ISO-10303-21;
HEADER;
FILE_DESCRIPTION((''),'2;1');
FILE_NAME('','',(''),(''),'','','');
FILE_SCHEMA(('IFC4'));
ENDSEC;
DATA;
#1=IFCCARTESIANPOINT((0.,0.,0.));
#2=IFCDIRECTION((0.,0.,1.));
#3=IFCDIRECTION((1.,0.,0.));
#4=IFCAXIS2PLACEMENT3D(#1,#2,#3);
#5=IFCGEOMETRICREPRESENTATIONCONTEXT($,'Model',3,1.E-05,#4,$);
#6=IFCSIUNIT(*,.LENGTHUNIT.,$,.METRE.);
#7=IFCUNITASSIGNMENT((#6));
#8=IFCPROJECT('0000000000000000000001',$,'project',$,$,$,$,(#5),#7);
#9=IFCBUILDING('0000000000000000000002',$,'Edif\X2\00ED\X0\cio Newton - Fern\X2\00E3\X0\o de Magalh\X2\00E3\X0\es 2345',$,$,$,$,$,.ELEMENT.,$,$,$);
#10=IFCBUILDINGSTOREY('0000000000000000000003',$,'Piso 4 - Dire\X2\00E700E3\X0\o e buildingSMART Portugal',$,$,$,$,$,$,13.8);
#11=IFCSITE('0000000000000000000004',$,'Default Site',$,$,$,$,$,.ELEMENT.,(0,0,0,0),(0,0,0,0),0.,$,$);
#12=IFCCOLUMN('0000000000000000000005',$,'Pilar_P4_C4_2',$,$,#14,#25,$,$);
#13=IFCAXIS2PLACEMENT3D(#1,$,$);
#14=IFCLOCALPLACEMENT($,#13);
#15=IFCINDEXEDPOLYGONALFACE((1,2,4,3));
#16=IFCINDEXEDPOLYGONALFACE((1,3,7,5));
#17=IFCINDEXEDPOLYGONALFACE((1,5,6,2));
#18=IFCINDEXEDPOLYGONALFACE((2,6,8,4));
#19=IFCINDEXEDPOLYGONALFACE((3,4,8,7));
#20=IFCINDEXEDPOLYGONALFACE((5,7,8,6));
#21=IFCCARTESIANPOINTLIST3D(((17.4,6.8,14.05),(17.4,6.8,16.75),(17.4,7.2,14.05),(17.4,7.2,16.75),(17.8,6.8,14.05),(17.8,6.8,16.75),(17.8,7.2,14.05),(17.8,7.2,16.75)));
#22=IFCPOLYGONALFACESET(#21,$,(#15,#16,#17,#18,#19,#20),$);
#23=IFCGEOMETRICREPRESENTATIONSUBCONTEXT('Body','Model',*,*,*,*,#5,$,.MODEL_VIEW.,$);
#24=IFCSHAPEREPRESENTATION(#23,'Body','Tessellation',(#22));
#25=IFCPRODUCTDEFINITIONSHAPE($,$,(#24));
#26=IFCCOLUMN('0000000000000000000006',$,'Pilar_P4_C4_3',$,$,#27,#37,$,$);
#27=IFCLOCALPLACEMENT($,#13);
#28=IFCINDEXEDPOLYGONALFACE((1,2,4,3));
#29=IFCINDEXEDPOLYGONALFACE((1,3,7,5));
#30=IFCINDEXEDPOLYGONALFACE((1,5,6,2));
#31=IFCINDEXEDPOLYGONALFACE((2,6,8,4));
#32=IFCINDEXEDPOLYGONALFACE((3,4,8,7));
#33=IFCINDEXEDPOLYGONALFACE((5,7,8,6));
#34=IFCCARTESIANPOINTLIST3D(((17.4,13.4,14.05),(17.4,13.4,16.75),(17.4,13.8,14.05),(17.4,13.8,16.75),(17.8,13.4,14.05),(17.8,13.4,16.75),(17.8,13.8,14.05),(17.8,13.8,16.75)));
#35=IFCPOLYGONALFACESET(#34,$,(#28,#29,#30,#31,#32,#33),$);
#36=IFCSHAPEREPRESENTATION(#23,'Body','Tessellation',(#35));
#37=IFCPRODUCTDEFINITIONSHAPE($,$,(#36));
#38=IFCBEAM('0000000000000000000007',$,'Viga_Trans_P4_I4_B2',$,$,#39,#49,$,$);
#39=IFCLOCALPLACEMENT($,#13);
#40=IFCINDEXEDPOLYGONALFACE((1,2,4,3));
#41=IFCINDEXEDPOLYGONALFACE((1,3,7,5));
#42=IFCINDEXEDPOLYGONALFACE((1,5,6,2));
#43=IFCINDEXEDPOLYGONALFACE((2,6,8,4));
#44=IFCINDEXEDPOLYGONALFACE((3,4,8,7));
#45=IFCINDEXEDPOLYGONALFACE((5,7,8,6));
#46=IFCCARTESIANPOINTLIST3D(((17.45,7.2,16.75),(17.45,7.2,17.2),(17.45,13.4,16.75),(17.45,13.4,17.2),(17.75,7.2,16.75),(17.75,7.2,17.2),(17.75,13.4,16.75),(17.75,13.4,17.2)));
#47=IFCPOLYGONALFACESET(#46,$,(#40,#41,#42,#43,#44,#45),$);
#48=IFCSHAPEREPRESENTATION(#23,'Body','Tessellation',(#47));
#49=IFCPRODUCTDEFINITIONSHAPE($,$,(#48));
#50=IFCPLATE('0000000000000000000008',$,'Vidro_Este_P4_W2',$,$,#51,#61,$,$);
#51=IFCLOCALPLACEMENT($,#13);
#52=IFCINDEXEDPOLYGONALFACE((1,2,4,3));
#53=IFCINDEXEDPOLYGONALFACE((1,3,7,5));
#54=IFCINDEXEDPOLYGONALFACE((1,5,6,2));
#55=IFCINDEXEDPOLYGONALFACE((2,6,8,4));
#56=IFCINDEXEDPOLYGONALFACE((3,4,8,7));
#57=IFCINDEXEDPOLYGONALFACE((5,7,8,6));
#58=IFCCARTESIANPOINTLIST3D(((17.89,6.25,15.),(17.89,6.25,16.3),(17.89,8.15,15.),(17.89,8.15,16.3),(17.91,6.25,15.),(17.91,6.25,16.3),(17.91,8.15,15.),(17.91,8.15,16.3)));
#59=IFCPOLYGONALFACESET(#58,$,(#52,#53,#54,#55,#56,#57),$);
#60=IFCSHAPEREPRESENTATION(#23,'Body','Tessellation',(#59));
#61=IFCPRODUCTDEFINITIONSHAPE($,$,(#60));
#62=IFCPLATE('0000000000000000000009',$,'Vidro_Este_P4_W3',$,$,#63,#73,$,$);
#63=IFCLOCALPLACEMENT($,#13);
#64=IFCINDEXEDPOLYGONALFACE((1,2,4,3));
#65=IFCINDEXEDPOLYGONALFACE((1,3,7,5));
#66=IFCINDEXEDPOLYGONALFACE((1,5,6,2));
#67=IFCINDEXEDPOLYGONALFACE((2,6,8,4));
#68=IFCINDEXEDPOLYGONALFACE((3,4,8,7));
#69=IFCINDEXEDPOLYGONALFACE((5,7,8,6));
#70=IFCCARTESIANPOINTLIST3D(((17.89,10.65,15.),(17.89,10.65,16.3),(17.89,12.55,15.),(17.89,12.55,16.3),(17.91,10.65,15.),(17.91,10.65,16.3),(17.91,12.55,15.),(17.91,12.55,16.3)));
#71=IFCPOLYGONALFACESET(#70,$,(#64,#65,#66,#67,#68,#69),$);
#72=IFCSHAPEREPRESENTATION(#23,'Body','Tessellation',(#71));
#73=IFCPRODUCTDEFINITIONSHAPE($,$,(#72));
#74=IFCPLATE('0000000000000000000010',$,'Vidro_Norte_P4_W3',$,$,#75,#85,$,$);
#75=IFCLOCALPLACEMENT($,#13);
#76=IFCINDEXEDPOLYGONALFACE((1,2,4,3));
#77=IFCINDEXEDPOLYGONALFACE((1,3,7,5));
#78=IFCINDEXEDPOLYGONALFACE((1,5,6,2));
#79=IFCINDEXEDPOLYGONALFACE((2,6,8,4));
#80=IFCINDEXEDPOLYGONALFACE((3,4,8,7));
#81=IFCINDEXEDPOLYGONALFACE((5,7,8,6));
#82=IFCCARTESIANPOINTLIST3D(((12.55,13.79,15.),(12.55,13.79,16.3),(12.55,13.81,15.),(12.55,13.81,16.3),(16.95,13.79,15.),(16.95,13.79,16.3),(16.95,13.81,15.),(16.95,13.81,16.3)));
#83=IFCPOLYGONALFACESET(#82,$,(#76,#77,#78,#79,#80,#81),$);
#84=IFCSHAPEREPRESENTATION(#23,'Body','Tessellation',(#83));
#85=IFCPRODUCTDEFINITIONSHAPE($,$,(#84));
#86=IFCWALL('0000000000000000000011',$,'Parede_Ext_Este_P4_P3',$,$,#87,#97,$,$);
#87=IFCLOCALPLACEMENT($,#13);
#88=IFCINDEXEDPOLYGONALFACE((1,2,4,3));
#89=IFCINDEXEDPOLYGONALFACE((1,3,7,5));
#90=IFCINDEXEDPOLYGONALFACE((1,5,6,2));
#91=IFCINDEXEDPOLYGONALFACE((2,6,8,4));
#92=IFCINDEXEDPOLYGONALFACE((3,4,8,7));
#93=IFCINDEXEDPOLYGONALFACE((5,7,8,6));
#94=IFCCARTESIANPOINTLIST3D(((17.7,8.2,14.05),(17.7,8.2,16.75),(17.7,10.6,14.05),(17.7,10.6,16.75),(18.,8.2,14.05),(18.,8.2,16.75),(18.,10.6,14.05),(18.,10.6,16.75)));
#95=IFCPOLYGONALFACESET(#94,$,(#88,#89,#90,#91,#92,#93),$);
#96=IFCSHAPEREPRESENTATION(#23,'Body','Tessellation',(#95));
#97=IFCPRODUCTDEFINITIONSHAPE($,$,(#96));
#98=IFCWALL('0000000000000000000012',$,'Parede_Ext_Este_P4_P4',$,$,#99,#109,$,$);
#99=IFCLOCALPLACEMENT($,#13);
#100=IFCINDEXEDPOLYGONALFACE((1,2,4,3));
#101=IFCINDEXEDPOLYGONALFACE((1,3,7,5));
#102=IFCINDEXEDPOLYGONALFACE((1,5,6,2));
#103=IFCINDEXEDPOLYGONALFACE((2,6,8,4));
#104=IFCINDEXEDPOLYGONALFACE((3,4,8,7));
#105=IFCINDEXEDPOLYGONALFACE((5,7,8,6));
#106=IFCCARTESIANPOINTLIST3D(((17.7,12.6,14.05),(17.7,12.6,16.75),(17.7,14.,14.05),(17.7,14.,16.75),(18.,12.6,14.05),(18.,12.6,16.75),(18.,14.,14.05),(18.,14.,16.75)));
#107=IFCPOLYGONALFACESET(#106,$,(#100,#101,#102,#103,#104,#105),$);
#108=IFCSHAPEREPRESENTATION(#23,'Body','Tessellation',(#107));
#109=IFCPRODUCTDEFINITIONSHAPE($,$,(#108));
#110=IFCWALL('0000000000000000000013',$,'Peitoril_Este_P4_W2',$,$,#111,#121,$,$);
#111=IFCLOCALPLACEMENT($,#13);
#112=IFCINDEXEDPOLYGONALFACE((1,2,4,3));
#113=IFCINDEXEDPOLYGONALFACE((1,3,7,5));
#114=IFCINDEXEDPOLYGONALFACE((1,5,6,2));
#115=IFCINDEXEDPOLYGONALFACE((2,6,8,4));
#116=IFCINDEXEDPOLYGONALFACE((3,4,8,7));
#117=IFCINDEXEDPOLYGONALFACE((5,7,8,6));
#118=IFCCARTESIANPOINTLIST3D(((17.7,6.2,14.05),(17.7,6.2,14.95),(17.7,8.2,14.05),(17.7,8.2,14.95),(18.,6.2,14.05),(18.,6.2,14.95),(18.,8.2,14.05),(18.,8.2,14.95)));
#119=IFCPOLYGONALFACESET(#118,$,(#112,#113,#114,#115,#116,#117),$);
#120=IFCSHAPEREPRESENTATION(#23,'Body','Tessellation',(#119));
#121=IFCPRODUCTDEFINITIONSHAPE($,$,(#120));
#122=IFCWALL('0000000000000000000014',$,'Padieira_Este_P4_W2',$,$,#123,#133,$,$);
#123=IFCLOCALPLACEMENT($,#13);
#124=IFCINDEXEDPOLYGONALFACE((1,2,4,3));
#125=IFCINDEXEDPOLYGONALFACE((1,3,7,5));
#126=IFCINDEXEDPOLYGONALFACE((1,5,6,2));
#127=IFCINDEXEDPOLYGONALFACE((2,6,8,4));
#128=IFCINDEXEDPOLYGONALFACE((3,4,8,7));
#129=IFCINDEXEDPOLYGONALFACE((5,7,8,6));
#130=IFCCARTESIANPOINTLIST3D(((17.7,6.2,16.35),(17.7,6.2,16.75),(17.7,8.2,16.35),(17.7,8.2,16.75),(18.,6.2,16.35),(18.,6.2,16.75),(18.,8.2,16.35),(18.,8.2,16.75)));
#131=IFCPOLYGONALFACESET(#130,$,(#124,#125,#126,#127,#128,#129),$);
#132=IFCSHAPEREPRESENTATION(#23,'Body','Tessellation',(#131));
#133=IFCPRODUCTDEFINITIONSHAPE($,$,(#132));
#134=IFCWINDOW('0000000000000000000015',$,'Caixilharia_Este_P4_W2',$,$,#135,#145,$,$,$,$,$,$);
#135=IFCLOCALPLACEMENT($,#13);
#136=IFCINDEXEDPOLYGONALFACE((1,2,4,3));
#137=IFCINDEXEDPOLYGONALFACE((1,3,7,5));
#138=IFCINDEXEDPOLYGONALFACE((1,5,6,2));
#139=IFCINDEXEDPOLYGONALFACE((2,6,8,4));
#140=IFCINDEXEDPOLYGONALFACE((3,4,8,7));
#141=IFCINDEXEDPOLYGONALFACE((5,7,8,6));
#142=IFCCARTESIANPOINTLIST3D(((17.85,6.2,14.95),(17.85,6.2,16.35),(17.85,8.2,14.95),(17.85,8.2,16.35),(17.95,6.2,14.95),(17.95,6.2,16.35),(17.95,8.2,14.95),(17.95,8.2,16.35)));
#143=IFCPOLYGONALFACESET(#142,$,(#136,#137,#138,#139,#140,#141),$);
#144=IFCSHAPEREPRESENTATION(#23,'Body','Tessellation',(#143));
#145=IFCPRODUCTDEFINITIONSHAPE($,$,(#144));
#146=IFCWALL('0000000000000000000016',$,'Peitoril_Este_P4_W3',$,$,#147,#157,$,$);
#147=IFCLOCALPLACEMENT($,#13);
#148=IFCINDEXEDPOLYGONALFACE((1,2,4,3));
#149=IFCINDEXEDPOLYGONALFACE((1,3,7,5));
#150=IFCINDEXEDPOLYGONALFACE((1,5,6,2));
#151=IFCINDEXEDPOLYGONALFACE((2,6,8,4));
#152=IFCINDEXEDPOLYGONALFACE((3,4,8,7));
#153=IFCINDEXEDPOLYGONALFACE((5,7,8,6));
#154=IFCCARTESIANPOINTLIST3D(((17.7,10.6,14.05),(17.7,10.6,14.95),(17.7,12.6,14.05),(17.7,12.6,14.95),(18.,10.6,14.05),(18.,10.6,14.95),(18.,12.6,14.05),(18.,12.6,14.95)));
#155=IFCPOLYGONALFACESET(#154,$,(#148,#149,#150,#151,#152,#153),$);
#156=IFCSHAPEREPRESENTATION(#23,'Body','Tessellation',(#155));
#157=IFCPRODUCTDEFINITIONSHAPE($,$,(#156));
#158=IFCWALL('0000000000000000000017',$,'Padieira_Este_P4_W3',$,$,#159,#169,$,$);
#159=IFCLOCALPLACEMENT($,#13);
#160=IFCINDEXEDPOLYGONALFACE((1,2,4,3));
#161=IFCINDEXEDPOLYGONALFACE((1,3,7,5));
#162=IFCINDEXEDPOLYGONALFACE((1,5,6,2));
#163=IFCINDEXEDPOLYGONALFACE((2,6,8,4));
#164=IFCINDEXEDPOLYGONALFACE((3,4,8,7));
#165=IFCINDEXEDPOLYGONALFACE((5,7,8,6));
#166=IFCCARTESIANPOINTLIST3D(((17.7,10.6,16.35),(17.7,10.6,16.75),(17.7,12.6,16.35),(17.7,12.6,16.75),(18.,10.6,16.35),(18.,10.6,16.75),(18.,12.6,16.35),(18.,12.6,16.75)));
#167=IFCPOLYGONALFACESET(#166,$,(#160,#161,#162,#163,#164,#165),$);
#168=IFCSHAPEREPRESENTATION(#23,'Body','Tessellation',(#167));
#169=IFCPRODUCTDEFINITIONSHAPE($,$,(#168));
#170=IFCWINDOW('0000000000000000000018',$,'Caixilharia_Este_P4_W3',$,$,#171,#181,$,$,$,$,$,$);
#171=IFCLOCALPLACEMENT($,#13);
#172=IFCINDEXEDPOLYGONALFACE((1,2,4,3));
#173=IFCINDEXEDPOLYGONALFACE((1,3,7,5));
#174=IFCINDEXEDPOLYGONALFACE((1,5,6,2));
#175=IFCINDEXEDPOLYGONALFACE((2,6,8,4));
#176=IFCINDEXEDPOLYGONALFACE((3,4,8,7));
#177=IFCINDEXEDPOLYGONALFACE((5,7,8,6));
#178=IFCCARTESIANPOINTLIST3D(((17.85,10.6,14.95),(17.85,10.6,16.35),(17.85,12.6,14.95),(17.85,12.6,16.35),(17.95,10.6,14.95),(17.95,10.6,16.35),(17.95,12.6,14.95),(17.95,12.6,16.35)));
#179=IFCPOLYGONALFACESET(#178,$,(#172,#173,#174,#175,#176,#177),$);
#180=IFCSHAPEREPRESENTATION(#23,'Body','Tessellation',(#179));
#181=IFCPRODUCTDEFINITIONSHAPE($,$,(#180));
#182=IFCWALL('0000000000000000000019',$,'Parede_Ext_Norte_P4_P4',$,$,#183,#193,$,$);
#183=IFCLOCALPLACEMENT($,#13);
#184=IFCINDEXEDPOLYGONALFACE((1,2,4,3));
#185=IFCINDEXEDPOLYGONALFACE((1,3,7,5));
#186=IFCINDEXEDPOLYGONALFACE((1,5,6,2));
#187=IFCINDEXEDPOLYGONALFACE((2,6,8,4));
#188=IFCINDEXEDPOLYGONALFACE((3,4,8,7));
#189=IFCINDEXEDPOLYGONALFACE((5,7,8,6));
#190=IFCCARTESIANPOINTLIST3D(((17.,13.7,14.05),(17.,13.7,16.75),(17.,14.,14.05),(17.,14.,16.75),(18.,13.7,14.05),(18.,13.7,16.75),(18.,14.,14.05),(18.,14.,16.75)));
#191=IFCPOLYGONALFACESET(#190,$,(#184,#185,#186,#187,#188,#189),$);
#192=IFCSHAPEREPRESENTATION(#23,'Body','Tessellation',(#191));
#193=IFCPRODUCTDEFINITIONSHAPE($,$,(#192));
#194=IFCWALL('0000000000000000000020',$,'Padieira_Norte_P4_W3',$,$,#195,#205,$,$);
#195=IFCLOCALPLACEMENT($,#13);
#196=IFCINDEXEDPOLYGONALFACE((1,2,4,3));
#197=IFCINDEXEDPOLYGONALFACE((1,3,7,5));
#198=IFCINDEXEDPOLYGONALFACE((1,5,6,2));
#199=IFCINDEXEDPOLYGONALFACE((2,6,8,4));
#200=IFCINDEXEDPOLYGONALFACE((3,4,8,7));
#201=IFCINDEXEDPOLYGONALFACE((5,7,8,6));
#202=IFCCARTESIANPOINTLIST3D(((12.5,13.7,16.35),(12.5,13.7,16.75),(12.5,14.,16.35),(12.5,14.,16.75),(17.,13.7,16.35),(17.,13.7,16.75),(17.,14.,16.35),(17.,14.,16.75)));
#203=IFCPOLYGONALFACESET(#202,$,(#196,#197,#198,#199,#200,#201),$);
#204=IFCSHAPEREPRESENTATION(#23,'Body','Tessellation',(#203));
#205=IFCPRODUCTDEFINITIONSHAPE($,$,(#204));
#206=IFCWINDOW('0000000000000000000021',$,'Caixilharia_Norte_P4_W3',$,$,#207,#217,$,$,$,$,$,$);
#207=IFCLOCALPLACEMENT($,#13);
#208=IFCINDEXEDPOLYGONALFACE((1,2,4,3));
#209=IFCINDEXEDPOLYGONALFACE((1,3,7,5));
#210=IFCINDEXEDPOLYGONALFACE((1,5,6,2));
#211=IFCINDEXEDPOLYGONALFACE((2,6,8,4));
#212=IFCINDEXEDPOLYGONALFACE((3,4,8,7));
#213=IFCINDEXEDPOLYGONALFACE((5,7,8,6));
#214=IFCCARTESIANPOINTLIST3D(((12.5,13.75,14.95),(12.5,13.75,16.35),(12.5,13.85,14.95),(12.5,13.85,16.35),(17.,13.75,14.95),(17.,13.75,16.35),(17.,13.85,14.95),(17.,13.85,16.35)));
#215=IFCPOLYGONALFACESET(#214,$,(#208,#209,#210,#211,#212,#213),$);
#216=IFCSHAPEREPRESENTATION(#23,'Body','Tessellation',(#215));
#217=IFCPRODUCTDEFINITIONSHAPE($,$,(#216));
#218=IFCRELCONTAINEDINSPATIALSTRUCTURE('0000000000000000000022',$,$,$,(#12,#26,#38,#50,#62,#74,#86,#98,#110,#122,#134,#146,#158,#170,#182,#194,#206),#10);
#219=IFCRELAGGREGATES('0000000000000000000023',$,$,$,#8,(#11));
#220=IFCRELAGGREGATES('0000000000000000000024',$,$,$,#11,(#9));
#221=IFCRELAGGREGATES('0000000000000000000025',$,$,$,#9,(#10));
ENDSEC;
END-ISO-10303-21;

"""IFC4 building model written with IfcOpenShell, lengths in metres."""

from ifc_helpers import new_model, si_unit, frame, frame_2d, origin_with_axes, place, context, subcontext, project, spatial, rectangle, extrude, element, save


model = new_model("IFC4")

# Units and contexts
model_context = context("Model", 3, precision=1e-05, world=origin_with_axes())
body_context = subcontext(model_context, "Body", "Model", "MODEL_VIEW")
ifc_project = project(units=[si_unit("LENGTHUNIT", "METRE")], contexts=[model_context])

# Site, building, storey
site = spatial("IfcSite", under=ifc_project, Name="Default Site", CompositionType="ELEMENT", RefLatitude=(0, 0, 0, 0), RefLongitude=(0, 0, 0, 0), RefElevation=0.0)
building = spatial("IfcBuilding", under=site, Name="Edifício Newton - Fernão de Magalhães 2345", CompositionType="ELEMENT")
storey = spatial("IfcBuildingStorey", under=building, Name="Piso 4 - Direção e buildingSMART Portugal", Elevation=13.8)

# Columns
for number, where, z_axis, x_axis, name in (
    (1, (17.4, 6.8, 14.05), (0.0, 0.0, 1.0), (1.0, 0.0, 0.0), "Pilar_P4_C4_2"),
    (2, (17.4, 13.4, 14.05), (0.0, 0.0, 1.0), (1.0, 0.0, 0.0), "Pilar_P4_C4_3"),
):
    element("IfcColumn", number, at=place(None, frame(where, z_axis=z_axis, x_axis=x_axis)), inside=storey, Name=name, context=body_context, shape_type="SweptSolid", body=[
        extrude(rectangle(XDim=0.4, YDim=0.4, at=frame_2d((0.2, 0.2))), origin_with_axes(), (0.0, 0.0, 1.0), 2.7),
    ])

# Beam
beam_placement = place(None, frame((17.45, 7.2, 16.75), z_axis=(0.0, 0.0, 1.0), x_axis=(1.0, 0.0, 0.0)))
element("IfcBeam", 3, at=beam_placement, inside=storey, Name="Viga_Trans_P4_I4_B2", context=body_context, shape_type="SweptSolid", body=[
    extrude(rectangle(XDim=0.3, YDim=6.2, at=frame_2d((0.15, 3.1))), origin_with_axes(), (0.0, 0.0, 1.0), 0.45),
])

# Plates
plate_1_placement = place(None, frame((17.89, 6.25, 15.0), z_axis=(0.0, 0.0, 1.0), x_axis=(1.0, 0.0, 0.0)))
element("IfcPlate", 4, at=plate_1_placement, inside=storey, Name="Vidro_Este_P4_W2", context=body_context, shape_type="SweptSolid", body=[
    extrude(rectangle(XDim=0.02, YDim=1.9, at=frame_2d((0.01, 0.95))), origin_with_axes(), (0.0, 0.0, 1.0), 1.3),
])
plate_2_placement = place(None, frame((17.89, 10.65, 15.0), z_axis=(0.0, 0.0, 1.0), x_axis=(1.0, 0.0, 0.0)))
element("IfcPlate", 5, at=plate_2_placement, inside=storey, Name="Vidro_Este_P4_W3", context=body_context, shape_type="SweptSolid", body=[
    extrude(rectangle(XDim=0.02, YDim=1.9, at=frame_2d((0.01, 0.95))), origin_with_axes(), (0.0, 0.0, 1.0), 1.3),
])
plate_3_placement = place(None, frame((12.55, 13.79, 15.0), z_axis=(0.0, 0.0, 1.0), x_axis=(1.0, 0.0, 0.0)))
element("IfcPlate", 6, at=plate_3_placement, inside=storey, Name="Vidro_Norte_P4_W3", context=body_context, shape_type="SweptSolid", body=[
    extrude(rectangle(XDim=4.4, YDim=0.02, at=frame_2d((2.2, 0.01))), origin_with_axes(), (0.0, 0.0, 1.0), 1.3),
])

# Walls
wall_1_placement = place(None, frame((17.7, 8.2, 14.05), z_axis=(0.0, 0.0, 1.0), x_axis=(1.0, 0.0, 0.0)))
element("IfcWall", 7, at=wall_1_placement, inside=storey, Name="Parede_Ext_Este_P4_P3", context=body_context, shape_type="SweptSolid", body=[
    extrude(rectangle(XDim=0.3, YDim=2.4, at=frame_2d((0.15, 1.2))), origin_with_axes(), (0.0, 0.0, 1.0), 2.7),
])
wall_2_placement = place(None, frame((17.7, 12.6, 14.05), z_axis=(0.0, 0.0, 1.0), x_axis=(1.0, 0.0, 0.0)))
element("IfcWall", 8, at=wall_2_placement, inside=storey, Name="Parede_Ext_Este_P4_P4", context=body_context, shape_type="SweptSolid", body=[
    extrude(rectangle(XDim=0.3, YDim=1.4, at=frame_2d((0.15, 0.7))), origin_with_axes(), (0.0, 0.0, 1.0), 2.7),
])
wall_3_placement = place(None, frame((17.7, 6.2, 14.05), z_axis=(0.0, 0.0, 1.0), x_axis=(1.0, 0.0, 0.0)))
element("IfcWall", 9, at=wall_3_placement, inside=storey, Name="Peitoril_Este_P4_W2", context=body_context, shape_type="SweptSolid", body=[
    extrude(rectangle(XDim=0.3, YDim=2.0, at=frame_2d((0.15, 1.0))), origin_with_axes(), (0.0, 0.0, 1.0), 0.9),
])
wall_4_placement = place(None, frame((17.7, 6.2, 16.35), z_axis=(0.0, 0.0, 1.0), x_axis=(1.0, 0.0, 0.0)))
element("IfcWall", 10, at=wall_4_placement, inside=storey, Name="Padieira_Este_P4_W2", context=body_context, shape_type="SweptSolid", body=[
    extrude(rectangle(XDim=0.3, YDim=2.0, at=frame_2d((0.15, 1.0))), origin_with_axes(), (0.0, 0.0, 1.0), 0.4),
])

# Window
window_1_placement = place(None, frame((17.85, 6.2, 14.95), z_axis=(0.0, 0.0, 1.0), x_axis=(1.0, 0.0, 0.0)))
element("IfcWindow", 11, at=window_1_placement, inside=storey, Name="Caixilharia_Este_P4_W2", context=body_context, shape_type="SweptSolid", body=[
    extrude(rectangle(XDim=0.1, YDim=2.0, at=frame_2d((0.05, 1.0))), origin_with_axes(), (0.0, 0.0, 1.0), 1.4),
])

# Walls
wall_5_placement = place(None, frame((17.7, 10.6, 14.05), z_axis=(0.0, 0.0, 1.0), x_axis=(1.0, 0.0, 0.0)))
element("IfcWall", 12, at=wall_5_placement, inside=storey, Name="Peitoril_Este_P4_W3", context=body_context, shape_type="SweptSolid", body=[
    extrude(rectangle(XDim=0.3, YDim=2.0, at=frame_2d((0.15, 1.0))), origin_with_axes(), (0.0, 0.0, 1.0), 0.9),
])
wall_6_placement = place(None, frame((17.7, 10.6, 16.35), z_axis=(0.0, 0.0, 1.0), x_axis=(1.0, 0.0, 0.0)))
element("IfcWall", 13, at=wall_6_placement, inside=storey, Name="Padieira_Este_P4_W3", context=body_context, shape_type="SweptSolid", body=[
    extrude(rectangle(XDim=0.3, YDim=2.0, at=frame_2d((0.15, 1.0))), origin_with_axes(), (0.0, 0.0, 1.0), 0.4),
])

# Window
window_2_placement = place(None, frame((17.85, 10.6, 14.95), z_axis=(0.0, 0.0, 1.0), x_axis=(1.0, 0.0, 0.0)))
element("IfcWindow", 14, at=window_2_placement, inside=storey, Name="Caixilharia_Este_P4_W3", context=body_context, shape_type="SweptSolid", body=[
    extrude(rectangle(XDim=0.1, YDim=2.0, at=frame_2d((0.05, 1.0))), origin_with_axes(), (0.0, 0.0, 1.0), 1.4),
])

# Walls
wall_7_placement = place(None, frame((17.0, 13.7, 14.05), z_axis=(0.0, 0.0, 1.0), x_axis=(1.0, 0.0, 0.0)))
element("IfcWall", 15, at=wall_7_placement, inside=storey, Name="Parede_Ext_Norte_P4_P4", context=body_context, shape_type="SweptSolid", body=[
    extrude(rectangle(XDim=1.0, YDim=0.3, at=frame_2d((0.5, 0.15))), origin_with_axes(), (0.0, 0.0, 1.0), 2.7),
])
wall_8_placement = place(None, frame((12.5, 13.7, 16.35), z_axis=(0.0, 0.0, 1.0), x_axis=(1.0, 0.0, 0.0)))
element("IfcWall", 16, at=wall_8_placement, inside=storey, Name="Padieira_Norte_P4_W3", context=body_context, shape_type="SweptSolid", body=[
    extrude(rectangle(XDim=4.5, YDim=0.3, at=frame_2d((2.25, 0.15))), origin_with_axes(), (0.0, 0.0, 1.0), 0.4),
])

# Window
window_3_placement = place(None, frame((12.5, 13.75, 14.95), z_axis=(0.0, 0.0, 1.0), x_axis=(1.0, 0.0, 0.0)))
element("IfcWindow", 17, at=window_3_placement, inside=storey, Name="Caixilharia_Norte_P4_W3", context=body_context, shape_type="SweptSolid", body=[
    extrude(rectangle(XDim=4.5, YDim=0.1, at=frame_2d((2.25, 0.05))), origin_with_axes(), (0.0, 0.0, 1.0), 1.4),
])

save(model, "model.ifc")
